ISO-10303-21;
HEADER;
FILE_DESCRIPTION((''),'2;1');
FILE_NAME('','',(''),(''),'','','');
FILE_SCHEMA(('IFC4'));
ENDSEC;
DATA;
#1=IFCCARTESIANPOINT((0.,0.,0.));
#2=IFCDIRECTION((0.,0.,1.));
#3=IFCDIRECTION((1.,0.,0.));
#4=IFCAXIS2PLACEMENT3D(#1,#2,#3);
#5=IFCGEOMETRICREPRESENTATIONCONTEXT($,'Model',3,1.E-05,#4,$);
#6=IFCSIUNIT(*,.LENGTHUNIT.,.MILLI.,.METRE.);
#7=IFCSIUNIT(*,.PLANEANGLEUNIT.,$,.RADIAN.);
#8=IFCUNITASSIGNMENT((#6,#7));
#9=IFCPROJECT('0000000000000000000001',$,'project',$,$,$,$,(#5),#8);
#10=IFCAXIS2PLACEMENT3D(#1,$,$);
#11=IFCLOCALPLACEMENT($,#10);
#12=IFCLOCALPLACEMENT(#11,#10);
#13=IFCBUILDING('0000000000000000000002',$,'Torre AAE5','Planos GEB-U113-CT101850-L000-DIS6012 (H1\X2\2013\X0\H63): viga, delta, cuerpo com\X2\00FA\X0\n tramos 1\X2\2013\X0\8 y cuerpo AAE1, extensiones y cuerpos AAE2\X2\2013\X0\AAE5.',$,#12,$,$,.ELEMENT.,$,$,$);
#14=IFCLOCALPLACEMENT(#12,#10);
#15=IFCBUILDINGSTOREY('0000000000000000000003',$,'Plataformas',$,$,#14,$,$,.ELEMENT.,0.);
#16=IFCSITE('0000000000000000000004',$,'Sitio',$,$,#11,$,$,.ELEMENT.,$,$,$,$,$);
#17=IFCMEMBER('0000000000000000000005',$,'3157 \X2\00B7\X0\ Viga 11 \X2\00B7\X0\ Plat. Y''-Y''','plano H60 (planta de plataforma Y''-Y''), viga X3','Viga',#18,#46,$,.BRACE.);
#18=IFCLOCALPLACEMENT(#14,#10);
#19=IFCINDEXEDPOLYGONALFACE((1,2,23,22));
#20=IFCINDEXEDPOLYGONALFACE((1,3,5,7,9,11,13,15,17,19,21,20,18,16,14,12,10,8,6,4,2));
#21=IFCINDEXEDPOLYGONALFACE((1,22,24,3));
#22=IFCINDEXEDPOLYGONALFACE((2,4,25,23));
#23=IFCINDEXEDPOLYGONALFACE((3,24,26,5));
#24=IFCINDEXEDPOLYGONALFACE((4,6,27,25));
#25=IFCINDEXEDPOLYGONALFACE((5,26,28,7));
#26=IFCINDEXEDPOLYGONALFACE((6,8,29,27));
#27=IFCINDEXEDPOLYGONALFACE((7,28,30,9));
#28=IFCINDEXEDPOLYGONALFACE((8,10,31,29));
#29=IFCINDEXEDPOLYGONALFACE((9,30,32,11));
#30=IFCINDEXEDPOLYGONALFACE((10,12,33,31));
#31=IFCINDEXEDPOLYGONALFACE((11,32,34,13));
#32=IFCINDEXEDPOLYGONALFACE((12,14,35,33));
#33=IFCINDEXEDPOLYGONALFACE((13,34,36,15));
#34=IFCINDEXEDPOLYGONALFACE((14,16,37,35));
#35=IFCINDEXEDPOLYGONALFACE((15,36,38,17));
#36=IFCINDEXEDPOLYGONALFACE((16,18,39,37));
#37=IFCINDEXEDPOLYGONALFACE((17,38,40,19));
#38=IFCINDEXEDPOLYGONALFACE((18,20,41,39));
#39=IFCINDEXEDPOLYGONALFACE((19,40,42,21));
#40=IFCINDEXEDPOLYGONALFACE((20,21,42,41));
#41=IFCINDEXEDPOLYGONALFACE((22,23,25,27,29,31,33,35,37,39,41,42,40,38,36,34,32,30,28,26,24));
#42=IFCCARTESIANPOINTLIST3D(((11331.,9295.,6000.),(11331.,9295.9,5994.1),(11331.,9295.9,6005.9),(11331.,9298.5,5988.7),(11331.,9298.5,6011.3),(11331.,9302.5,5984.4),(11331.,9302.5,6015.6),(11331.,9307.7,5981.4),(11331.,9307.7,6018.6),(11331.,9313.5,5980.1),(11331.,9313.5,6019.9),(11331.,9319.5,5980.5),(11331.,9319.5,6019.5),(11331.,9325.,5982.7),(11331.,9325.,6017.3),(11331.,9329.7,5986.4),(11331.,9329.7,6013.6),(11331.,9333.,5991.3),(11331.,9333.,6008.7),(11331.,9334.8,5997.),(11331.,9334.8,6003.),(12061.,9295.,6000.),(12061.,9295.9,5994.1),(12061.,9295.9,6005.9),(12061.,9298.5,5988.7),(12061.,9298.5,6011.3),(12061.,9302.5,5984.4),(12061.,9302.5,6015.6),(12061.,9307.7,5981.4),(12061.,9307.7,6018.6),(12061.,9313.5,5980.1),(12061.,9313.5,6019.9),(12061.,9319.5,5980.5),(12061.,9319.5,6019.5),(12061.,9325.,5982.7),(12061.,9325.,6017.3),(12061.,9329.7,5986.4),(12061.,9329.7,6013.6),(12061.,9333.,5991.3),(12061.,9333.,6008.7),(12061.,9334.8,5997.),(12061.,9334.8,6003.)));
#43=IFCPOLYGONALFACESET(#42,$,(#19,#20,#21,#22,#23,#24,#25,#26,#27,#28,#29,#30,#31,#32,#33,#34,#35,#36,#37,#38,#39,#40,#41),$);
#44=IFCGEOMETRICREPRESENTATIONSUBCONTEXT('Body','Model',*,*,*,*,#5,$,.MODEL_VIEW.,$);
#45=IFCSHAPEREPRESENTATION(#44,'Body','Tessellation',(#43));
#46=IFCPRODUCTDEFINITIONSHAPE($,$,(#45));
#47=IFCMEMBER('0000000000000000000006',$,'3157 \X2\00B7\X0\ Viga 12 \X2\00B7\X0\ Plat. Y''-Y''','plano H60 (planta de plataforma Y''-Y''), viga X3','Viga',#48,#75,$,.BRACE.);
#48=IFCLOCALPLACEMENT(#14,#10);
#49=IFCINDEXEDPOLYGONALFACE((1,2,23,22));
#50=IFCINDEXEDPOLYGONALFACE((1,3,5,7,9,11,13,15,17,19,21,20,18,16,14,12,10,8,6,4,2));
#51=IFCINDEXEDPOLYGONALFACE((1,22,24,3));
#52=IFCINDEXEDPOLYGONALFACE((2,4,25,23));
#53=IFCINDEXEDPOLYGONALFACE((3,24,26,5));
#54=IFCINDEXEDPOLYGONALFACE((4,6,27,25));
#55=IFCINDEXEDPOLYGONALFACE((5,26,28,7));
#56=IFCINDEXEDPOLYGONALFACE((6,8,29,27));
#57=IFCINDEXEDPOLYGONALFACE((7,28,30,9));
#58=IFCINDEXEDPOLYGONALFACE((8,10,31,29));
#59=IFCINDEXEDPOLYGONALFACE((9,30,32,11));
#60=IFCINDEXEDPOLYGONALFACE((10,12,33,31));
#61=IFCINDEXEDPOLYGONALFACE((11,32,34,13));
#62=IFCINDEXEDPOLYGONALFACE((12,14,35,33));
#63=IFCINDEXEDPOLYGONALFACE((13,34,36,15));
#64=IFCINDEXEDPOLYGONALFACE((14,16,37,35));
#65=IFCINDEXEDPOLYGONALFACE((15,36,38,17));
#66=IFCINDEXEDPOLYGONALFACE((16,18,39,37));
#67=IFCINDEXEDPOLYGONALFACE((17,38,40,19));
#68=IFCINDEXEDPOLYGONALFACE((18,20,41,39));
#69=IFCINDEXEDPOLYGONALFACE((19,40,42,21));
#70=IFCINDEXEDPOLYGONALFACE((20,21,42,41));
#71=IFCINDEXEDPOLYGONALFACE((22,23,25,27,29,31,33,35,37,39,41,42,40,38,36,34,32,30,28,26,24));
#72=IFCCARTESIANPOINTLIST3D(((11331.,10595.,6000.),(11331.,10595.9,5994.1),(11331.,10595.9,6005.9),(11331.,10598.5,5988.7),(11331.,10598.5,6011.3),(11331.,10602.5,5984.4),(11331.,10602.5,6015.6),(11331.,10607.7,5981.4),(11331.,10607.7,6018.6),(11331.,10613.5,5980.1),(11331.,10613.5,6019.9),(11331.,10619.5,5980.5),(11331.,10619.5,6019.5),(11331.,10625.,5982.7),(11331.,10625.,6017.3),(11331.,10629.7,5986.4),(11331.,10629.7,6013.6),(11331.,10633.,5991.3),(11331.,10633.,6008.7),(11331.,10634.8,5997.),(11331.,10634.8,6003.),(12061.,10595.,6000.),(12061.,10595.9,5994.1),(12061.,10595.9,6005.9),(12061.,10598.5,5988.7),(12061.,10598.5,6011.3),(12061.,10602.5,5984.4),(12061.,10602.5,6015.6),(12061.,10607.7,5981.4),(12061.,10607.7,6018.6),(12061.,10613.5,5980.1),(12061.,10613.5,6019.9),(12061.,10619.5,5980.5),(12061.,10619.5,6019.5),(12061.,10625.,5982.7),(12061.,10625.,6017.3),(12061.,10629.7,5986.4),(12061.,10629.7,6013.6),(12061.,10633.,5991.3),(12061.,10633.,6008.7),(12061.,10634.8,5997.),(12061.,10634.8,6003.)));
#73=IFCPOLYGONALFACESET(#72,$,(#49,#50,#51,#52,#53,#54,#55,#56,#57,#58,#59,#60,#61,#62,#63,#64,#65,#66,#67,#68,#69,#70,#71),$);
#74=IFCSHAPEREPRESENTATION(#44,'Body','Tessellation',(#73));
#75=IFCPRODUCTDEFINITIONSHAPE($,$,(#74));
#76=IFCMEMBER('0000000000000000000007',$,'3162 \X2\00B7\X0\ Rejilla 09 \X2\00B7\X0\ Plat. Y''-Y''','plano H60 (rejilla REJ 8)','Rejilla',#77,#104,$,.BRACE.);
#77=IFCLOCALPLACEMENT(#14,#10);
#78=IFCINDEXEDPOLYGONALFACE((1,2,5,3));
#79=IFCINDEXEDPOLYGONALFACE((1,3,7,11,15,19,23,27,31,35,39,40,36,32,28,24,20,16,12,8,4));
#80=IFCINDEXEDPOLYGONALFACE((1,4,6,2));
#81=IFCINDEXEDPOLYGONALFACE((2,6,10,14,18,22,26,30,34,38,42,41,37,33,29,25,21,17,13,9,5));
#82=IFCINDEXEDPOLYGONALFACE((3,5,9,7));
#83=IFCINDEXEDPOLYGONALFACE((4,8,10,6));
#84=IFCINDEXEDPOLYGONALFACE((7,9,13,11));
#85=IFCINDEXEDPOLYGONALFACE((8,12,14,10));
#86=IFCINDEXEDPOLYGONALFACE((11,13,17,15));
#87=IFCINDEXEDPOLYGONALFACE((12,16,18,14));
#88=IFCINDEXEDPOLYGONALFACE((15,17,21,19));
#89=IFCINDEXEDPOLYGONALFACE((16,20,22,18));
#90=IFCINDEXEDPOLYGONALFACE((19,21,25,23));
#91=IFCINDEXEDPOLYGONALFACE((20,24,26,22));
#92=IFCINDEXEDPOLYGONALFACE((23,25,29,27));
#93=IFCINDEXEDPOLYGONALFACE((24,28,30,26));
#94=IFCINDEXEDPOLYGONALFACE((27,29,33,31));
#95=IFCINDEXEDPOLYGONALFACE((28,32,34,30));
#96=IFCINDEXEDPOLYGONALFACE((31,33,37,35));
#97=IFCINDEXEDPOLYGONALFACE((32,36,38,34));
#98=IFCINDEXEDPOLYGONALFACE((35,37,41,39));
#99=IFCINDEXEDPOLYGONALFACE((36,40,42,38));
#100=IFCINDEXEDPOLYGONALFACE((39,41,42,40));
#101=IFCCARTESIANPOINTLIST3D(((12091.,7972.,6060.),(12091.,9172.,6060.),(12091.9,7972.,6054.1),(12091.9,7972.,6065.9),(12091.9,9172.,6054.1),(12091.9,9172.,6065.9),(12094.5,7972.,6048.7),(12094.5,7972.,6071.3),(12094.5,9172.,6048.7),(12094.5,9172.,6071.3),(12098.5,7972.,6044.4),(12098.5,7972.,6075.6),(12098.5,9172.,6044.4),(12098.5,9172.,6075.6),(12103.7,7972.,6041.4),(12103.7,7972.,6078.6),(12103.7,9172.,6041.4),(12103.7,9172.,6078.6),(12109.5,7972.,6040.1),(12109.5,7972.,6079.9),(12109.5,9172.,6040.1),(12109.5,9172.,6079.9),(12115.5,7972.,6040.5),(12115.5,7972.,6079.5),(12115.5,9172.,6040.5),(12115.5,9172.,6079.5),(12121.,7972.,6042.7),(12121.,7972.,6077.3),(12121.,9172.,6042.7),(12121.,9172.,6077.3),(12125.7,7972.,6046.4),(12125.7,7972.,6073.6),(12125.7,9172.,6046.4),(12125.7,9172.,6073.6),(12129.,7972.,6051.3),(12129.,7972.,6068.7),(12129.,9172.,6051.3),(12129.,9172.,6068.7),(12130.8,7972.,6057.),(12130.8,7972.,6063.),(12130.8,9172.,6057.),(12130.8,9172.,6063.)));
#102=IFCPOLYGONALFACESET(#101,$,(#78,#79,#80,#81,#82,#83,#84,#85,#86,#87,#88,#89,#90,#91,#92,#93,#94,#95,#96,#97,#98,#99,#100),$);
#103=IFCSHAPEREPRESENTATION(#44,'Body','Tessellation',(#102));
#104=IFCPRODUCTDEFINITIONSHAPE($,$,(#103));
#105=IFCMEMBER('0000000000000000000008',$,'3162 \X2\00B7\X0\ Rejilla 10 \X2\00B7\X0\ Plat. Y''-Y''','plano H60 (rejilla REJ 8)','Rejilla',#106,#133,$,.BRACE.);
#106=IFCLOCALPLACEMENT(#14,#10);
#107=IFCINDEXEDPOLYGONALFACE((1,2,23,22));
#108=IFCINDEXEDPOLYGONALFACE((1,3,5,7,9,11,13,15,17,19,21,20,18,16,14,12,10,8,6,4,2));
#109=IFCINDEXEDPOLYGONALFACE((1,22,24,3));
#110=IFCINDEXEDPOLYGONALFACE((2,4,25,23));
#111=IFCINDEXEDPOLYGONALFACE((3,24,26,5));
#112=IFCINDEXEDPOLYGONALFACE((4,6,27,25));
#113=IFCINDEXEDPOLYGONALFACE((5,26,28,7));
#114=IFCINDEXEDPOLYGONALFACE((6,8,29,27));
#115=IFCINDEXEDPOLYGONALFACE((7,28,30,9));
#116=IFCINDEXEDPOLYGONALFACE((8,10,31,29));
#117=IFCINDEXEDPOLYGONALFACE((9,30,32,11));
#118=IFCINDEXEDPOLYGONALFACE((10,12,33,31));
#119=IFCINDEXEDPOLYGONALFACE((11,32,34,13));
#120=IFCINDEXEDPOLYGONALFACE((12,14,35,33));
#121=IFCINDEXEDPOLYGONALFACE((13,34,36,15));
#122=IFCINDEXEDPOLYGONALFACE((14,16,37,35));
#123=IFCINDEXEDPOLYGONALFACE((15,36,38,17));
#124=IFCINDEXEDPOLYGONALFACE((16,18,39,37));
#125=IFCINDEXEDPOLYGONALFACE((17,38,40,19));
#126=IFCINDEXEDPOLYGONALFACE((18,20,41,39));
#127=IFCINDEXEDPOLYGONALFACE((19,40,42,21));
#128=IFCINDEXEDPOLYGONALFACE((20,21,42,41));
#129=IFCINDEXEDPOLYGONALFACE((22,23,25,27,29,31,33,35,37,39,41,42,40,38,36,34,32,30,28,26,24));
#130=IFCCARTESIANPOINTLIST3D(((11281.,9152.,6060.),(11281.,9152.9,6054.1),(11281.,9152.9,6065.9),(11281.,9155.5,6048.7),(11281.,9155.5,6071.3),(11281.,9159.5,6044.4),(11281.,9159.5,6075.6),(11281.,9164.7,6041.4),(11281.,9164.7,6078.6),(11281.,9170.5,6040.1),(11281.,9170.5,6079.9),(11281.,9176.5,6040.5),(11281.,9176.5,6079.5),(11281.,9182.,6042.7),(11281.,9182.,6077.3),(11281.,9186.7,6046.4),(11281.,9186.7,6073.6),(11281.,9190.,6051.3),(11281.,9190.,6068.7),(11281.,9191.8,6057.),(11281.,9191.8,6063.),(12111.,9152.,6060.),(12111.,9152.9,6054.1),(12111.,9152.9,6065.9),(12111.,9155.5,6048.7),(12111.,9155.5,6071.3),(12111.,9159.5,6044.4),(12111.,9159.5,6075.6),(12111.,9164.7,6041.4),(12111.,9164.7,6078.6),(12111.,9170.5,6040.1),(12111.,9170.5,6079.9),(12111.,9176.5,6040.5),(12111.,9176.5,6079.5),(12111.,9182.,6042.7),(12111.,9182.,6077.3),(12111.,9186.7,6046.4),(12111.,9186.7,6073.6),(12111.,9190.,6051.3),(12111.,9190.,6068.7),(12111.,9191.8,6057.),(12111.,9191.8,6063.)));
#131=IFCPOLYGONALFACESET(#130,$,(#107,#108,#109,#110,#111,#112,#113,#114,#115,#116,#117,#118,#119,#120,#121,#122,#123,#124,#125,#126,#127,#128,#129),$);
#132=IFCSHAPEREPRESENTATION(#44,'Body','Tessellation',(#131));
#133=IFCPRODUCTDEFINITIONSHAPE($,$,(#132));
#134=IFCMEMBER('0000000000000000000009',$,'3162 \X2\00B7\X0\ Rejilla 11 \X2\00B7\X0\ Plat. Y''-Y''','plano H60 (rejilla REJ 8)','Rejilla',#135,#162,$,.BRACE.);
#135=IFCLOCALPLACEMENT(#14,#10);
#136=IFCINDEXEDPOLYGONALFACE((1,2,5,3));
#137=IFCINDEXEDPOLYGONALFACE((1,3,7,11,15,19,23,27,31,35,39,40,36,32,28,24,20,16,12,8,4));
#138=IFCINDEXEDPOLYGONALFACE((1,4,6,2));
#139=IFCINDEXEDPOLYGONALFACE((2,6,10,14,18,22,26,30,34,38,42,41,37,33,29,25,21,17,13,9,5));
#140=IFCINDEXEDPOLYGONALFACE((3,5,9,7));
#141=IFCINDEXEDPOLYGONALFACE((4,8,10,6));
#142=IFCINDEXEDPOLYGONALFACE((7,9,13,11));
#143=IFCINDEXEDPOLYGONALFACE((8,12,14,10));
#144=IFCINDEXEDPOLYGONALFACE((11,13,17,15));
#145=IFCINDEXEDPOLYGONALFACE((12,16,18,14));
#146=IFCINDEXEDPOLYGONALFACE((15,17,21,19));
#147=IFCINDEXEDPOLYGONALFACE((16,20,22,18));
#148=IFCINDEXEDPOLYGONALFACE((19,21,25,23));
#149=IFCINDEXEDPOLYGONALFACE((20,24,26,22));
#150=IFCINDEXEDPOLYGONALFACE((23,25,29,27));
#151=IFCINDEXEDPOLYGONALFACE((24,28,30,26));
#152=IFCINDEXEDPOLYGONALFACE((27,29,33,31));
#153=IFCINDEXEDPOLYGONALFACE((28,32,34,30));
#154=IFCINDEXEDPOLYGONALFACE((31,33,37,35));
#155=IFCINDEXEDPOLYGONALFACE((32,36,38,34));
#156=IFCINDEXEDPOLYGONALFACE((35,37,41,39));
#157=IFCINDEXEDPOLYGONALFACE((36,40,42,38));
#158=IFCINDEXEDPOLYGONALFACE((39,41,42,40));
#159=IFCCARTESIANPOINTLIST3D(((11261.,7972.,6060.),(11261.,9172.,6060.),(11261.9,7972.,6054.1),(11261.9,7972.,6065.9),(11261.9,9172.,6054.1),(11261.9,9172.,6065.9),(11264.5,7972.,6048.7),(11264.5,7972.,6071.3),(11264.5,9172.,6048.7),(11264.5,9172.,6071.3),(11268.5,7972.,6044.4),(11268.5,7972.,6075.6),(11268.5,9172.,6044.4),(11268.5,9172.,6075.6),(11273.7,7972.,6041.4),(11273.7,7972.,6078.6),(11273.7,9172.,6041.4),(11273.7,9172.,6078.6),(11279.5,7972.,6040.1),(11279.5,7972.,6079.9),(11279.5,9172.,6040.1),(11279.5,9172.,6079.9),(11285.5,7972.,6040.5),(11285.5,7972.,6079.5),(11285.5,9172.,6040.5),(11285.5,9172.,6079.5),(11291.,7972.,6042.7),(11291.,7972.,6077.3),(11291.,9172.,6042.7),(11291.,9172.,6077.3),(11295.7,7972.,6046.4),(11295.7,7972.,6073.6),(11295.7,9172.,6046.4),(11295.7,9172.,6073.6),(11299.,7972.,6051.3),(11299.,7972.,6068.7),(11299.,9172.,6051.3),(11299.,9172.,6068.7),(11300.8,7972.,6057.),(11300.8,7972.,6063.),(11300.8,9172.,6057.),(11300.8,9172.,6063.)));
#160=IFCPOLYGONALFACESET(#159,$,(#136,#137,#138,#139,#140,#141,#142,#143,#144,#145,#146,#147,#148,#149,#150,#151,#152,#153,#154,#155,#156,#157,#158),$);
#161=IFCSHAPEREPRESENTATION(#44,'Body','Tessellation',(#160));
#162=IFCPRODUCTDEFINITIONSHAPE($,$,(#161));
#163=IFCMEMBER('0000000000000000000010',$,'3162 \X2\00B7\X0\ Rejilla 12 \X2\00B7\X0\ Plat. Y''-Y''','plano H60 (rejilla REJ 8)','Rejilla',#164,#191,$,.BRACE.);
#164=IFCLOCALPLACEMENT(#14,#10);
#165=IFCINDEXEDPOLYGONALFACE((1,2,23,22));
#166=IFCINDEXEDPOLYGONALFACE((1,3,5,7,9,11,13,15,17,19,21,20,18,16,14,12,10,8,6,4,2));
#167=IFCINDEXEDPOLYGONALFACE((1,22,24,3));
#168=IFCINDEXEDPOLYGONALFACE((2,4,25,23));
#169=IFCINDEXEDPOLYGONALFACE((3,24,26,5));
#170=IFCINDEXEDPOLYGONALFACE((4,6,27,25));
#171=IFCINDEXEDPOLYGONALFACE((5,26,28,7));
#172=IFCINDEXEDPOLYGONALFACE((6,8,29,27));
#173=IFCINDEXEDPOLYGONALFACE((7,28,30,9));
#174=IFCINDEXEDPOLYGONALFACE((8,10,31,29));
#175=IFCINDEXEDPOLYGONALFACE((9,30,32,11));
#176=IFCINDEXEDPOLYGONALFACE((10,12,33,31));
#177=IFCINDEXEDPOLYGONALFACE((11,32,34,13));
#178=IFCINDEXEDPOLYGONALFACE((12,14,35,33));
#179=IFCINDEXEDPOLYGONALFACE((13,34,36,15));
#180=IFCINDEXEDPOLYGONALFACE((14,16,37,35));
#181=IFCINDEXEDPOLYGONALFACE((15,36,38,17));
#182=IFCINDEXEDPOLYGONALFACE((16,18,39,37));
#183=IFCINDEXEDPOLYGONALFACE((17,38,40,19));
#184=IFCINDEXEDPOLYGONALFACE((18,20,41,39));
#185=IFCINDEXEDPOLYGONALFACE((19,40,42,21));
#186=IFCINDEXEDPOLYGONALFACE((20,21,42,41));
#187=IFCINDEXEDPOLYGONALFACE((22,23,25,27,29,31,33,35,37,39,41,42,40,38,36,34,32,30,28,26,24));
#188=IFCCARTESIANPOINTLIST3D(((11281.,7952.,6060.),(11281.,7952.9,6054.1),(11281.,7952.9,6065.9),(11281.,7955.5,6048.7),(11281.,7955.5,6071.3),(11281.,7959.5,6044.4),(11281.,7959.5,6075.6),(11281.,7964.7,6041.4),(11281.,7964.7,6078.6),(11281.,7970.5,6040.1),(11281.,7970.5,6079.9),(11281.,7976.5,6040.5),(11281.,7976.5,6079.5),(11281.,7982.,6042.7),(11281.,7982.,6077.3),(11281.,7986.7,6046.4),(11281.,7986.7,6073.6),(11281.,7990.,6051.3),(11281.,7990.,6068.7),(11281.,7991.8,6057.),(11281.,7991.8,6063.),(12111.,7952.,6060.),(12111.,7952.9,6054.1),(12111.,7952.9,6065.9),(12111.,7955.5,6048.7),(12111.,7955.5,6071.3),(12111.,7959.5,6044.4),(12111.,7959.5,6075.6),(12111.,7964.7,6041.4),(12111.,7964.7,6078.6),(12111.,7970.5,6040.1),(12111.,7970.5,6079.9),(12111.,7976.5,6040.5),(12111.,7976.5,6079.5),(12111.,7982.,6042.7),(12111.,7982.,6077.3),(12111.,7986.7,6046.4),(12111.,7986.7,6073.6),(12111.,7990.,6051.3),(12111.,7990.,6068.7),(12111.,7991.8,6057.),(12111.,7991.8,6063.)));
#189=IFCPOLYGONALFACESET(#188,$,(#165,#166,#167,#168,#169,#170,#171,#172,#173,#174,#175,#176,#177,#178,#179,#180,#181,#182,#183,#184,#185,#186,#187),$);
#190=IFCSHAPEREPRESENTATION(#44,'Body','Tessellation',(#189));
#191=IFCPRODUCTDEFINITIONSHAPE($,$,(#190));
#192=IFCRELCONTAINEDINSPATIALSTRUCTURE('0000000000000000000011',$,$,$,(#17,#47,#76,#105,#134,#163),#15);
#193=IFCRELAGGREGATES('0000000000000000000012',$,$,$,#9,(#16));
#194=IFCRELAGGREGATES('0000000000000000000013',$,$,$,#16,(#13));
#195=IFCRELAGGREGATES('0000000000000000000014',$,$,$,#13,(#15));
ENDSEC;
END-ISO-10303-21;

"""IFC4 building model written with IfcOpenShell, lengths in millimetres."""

from ifc_helpers import new_model, si_unit, frame, origin, origin_with_axes, place, context, subcontext, project, spatial, circle, extrude, element, save


model = new_model("IFC4")

# Units and contexts
model_context = context("Model", 3, precision=1e-05, world=origin_with_axes())
body_context = subcontext(model_context, "Body", "Model", "MODEL_VIEW")
ifc_project = project(units=[si_unit("LENGTHUNIT", "METRE", prefix="MILLI"), si_unit("PLANEANGLEUNIT", "RADIAN")], contexts=[model_context])

# Site, building, storey
site_placement = place(None, origin())
site = spatial("IfcSite", under=ifc_project, at=site_placement, Name="Sitio", CompositionType="ELEMENT")
building_placement = place(site_placement, origin())
building = spatial("IfcBuilding", under=site, at=building_placement, Name="Torre AAE5", Description="Planos GEB-U113-CT101850-L000-DIS6012 (H1–H63): viga, delta, cuerpo común tramos 1–8 y cuerpo AAE1, extensiones y cuerpos AAE2–AAE5.", CompositionType="ELEMENT")
storey_placement = place(building_placement, origin())
storey = spatial("IfcBuildingStorey", under=building, at=storey_placement, Name="Plataformas", CompositionType="ELEMENT", Elevation=0.0)

# Members
for number, where, z_axis, x_axis, name in (
    (1, (12061.0, 9315.0, 6000.0), (-1.0, 0.0, 0.0), (0.0, -1.0, 0.0), "3157 · Viga 11 · Plat. Y'-Y'"),
    (2, (12061.0, 10615.0, 6000.0), (-1.0, 0.0, 0.0), (0.0, -1.0, 0.0), "3157 · Viga 12 · Plat. Y'-Y'"),
):
    element("IfcMember", number, at=place(storey_placement, frame(where, z_axis=z_axis, x_axis=x_axis)), inside=storey, Name=name, Description="plano H60 (planta de plataforma Y'-Y'), viga X3", ObjectType="Viga", PredefinedType="BRACE", context=body_context, shape_type="SweptSolid", body=[
        extrude(circle(Radius=20.0), None, (0.0, 0.0, 1.0), 730.0),
    ])
member_1_placement = place(storey_placement, frame((12111.0, 7972.0, 6060.0), z_axis=(0.0, 1.0, 0.0), x_axis=(-1.0, 0.0, 0.0)))
element("IfcMember", 3, at=member_1_placement, inside=storey, Name="3162 · Rejilla 09 · Plat. Y'-Y'", Description="plano H60 (rejilla REJ 8)", ObjectType="Rejilla", PredefinedType="BRACE", context=body_context, shape_type="SweptSolid", body=[
    extrude(circle(Radius=20.0), None, (0.0, 0.0, 1.0), 1200.0),
])
member_2_placement = place(storey_placement, frame((12111.0, 9172.0, 6060.0), z_axis=(-1.0, 0.0, 0.0), x_axis=(0.0, -1.0, 0.0)))
element("IfcMember", 4, at=member_2_placement, inside=storey, Name="3162 · Rejilla 10 · Plat. Y'-Y'", Description="plano H60 (rejilla REJ 8)", ObjectType="Rejilla", PredefinedType="BRACE", context=body_context, shape_type="SweptSolid", body=[
    extrude(circle(Radius=20.0), None, (0.0, 0.0, 1.0), 830.0),
])
member_3_placement = place(storey_placement, frame((11281.0, 9172.0, 6060.0), z_axis=(0.0, -1.0, 0.0), x_axis=(-1.0, 0.0, 0.0)))
element("IfcMember", 5, at=member_3_placement, inside=storey, Name="3162 · Rejilla 11 · Plat. Y'-Y'", Description="plano H60 (rejilla REJ 8)", ObjectType="Rejilla", PredefinedType="BRACE", context=body_context, shape_type="SweptSolid", body=[
    extrude(circle(Radius=20.0), None, (0.0, 0.0, 1.0), 1200.0),
])
member_4_placement = place(storey_placement, frame((11281.0, 7972.0, 6060.0), z_axis=(1.0, 0.0, 0.0), x_axis=(0.0, -1.0, 0.0)))
element("IfcMember", 6, at=member_4_placement, inside=storey, Name="3162 · Rejilla 12 · Plat. Y'-Y'", Description="plano H60 (rejilla REJ 8)", ObjectType="Rejilla", PredefinedType="BRACE", context=body_context, shape_type="SweptSolid", body=[
    extrude(circle(Radius=20.0), None, (0.0, 0.0, 1.0), 830.0),
])

save(model, "model.ifc")
